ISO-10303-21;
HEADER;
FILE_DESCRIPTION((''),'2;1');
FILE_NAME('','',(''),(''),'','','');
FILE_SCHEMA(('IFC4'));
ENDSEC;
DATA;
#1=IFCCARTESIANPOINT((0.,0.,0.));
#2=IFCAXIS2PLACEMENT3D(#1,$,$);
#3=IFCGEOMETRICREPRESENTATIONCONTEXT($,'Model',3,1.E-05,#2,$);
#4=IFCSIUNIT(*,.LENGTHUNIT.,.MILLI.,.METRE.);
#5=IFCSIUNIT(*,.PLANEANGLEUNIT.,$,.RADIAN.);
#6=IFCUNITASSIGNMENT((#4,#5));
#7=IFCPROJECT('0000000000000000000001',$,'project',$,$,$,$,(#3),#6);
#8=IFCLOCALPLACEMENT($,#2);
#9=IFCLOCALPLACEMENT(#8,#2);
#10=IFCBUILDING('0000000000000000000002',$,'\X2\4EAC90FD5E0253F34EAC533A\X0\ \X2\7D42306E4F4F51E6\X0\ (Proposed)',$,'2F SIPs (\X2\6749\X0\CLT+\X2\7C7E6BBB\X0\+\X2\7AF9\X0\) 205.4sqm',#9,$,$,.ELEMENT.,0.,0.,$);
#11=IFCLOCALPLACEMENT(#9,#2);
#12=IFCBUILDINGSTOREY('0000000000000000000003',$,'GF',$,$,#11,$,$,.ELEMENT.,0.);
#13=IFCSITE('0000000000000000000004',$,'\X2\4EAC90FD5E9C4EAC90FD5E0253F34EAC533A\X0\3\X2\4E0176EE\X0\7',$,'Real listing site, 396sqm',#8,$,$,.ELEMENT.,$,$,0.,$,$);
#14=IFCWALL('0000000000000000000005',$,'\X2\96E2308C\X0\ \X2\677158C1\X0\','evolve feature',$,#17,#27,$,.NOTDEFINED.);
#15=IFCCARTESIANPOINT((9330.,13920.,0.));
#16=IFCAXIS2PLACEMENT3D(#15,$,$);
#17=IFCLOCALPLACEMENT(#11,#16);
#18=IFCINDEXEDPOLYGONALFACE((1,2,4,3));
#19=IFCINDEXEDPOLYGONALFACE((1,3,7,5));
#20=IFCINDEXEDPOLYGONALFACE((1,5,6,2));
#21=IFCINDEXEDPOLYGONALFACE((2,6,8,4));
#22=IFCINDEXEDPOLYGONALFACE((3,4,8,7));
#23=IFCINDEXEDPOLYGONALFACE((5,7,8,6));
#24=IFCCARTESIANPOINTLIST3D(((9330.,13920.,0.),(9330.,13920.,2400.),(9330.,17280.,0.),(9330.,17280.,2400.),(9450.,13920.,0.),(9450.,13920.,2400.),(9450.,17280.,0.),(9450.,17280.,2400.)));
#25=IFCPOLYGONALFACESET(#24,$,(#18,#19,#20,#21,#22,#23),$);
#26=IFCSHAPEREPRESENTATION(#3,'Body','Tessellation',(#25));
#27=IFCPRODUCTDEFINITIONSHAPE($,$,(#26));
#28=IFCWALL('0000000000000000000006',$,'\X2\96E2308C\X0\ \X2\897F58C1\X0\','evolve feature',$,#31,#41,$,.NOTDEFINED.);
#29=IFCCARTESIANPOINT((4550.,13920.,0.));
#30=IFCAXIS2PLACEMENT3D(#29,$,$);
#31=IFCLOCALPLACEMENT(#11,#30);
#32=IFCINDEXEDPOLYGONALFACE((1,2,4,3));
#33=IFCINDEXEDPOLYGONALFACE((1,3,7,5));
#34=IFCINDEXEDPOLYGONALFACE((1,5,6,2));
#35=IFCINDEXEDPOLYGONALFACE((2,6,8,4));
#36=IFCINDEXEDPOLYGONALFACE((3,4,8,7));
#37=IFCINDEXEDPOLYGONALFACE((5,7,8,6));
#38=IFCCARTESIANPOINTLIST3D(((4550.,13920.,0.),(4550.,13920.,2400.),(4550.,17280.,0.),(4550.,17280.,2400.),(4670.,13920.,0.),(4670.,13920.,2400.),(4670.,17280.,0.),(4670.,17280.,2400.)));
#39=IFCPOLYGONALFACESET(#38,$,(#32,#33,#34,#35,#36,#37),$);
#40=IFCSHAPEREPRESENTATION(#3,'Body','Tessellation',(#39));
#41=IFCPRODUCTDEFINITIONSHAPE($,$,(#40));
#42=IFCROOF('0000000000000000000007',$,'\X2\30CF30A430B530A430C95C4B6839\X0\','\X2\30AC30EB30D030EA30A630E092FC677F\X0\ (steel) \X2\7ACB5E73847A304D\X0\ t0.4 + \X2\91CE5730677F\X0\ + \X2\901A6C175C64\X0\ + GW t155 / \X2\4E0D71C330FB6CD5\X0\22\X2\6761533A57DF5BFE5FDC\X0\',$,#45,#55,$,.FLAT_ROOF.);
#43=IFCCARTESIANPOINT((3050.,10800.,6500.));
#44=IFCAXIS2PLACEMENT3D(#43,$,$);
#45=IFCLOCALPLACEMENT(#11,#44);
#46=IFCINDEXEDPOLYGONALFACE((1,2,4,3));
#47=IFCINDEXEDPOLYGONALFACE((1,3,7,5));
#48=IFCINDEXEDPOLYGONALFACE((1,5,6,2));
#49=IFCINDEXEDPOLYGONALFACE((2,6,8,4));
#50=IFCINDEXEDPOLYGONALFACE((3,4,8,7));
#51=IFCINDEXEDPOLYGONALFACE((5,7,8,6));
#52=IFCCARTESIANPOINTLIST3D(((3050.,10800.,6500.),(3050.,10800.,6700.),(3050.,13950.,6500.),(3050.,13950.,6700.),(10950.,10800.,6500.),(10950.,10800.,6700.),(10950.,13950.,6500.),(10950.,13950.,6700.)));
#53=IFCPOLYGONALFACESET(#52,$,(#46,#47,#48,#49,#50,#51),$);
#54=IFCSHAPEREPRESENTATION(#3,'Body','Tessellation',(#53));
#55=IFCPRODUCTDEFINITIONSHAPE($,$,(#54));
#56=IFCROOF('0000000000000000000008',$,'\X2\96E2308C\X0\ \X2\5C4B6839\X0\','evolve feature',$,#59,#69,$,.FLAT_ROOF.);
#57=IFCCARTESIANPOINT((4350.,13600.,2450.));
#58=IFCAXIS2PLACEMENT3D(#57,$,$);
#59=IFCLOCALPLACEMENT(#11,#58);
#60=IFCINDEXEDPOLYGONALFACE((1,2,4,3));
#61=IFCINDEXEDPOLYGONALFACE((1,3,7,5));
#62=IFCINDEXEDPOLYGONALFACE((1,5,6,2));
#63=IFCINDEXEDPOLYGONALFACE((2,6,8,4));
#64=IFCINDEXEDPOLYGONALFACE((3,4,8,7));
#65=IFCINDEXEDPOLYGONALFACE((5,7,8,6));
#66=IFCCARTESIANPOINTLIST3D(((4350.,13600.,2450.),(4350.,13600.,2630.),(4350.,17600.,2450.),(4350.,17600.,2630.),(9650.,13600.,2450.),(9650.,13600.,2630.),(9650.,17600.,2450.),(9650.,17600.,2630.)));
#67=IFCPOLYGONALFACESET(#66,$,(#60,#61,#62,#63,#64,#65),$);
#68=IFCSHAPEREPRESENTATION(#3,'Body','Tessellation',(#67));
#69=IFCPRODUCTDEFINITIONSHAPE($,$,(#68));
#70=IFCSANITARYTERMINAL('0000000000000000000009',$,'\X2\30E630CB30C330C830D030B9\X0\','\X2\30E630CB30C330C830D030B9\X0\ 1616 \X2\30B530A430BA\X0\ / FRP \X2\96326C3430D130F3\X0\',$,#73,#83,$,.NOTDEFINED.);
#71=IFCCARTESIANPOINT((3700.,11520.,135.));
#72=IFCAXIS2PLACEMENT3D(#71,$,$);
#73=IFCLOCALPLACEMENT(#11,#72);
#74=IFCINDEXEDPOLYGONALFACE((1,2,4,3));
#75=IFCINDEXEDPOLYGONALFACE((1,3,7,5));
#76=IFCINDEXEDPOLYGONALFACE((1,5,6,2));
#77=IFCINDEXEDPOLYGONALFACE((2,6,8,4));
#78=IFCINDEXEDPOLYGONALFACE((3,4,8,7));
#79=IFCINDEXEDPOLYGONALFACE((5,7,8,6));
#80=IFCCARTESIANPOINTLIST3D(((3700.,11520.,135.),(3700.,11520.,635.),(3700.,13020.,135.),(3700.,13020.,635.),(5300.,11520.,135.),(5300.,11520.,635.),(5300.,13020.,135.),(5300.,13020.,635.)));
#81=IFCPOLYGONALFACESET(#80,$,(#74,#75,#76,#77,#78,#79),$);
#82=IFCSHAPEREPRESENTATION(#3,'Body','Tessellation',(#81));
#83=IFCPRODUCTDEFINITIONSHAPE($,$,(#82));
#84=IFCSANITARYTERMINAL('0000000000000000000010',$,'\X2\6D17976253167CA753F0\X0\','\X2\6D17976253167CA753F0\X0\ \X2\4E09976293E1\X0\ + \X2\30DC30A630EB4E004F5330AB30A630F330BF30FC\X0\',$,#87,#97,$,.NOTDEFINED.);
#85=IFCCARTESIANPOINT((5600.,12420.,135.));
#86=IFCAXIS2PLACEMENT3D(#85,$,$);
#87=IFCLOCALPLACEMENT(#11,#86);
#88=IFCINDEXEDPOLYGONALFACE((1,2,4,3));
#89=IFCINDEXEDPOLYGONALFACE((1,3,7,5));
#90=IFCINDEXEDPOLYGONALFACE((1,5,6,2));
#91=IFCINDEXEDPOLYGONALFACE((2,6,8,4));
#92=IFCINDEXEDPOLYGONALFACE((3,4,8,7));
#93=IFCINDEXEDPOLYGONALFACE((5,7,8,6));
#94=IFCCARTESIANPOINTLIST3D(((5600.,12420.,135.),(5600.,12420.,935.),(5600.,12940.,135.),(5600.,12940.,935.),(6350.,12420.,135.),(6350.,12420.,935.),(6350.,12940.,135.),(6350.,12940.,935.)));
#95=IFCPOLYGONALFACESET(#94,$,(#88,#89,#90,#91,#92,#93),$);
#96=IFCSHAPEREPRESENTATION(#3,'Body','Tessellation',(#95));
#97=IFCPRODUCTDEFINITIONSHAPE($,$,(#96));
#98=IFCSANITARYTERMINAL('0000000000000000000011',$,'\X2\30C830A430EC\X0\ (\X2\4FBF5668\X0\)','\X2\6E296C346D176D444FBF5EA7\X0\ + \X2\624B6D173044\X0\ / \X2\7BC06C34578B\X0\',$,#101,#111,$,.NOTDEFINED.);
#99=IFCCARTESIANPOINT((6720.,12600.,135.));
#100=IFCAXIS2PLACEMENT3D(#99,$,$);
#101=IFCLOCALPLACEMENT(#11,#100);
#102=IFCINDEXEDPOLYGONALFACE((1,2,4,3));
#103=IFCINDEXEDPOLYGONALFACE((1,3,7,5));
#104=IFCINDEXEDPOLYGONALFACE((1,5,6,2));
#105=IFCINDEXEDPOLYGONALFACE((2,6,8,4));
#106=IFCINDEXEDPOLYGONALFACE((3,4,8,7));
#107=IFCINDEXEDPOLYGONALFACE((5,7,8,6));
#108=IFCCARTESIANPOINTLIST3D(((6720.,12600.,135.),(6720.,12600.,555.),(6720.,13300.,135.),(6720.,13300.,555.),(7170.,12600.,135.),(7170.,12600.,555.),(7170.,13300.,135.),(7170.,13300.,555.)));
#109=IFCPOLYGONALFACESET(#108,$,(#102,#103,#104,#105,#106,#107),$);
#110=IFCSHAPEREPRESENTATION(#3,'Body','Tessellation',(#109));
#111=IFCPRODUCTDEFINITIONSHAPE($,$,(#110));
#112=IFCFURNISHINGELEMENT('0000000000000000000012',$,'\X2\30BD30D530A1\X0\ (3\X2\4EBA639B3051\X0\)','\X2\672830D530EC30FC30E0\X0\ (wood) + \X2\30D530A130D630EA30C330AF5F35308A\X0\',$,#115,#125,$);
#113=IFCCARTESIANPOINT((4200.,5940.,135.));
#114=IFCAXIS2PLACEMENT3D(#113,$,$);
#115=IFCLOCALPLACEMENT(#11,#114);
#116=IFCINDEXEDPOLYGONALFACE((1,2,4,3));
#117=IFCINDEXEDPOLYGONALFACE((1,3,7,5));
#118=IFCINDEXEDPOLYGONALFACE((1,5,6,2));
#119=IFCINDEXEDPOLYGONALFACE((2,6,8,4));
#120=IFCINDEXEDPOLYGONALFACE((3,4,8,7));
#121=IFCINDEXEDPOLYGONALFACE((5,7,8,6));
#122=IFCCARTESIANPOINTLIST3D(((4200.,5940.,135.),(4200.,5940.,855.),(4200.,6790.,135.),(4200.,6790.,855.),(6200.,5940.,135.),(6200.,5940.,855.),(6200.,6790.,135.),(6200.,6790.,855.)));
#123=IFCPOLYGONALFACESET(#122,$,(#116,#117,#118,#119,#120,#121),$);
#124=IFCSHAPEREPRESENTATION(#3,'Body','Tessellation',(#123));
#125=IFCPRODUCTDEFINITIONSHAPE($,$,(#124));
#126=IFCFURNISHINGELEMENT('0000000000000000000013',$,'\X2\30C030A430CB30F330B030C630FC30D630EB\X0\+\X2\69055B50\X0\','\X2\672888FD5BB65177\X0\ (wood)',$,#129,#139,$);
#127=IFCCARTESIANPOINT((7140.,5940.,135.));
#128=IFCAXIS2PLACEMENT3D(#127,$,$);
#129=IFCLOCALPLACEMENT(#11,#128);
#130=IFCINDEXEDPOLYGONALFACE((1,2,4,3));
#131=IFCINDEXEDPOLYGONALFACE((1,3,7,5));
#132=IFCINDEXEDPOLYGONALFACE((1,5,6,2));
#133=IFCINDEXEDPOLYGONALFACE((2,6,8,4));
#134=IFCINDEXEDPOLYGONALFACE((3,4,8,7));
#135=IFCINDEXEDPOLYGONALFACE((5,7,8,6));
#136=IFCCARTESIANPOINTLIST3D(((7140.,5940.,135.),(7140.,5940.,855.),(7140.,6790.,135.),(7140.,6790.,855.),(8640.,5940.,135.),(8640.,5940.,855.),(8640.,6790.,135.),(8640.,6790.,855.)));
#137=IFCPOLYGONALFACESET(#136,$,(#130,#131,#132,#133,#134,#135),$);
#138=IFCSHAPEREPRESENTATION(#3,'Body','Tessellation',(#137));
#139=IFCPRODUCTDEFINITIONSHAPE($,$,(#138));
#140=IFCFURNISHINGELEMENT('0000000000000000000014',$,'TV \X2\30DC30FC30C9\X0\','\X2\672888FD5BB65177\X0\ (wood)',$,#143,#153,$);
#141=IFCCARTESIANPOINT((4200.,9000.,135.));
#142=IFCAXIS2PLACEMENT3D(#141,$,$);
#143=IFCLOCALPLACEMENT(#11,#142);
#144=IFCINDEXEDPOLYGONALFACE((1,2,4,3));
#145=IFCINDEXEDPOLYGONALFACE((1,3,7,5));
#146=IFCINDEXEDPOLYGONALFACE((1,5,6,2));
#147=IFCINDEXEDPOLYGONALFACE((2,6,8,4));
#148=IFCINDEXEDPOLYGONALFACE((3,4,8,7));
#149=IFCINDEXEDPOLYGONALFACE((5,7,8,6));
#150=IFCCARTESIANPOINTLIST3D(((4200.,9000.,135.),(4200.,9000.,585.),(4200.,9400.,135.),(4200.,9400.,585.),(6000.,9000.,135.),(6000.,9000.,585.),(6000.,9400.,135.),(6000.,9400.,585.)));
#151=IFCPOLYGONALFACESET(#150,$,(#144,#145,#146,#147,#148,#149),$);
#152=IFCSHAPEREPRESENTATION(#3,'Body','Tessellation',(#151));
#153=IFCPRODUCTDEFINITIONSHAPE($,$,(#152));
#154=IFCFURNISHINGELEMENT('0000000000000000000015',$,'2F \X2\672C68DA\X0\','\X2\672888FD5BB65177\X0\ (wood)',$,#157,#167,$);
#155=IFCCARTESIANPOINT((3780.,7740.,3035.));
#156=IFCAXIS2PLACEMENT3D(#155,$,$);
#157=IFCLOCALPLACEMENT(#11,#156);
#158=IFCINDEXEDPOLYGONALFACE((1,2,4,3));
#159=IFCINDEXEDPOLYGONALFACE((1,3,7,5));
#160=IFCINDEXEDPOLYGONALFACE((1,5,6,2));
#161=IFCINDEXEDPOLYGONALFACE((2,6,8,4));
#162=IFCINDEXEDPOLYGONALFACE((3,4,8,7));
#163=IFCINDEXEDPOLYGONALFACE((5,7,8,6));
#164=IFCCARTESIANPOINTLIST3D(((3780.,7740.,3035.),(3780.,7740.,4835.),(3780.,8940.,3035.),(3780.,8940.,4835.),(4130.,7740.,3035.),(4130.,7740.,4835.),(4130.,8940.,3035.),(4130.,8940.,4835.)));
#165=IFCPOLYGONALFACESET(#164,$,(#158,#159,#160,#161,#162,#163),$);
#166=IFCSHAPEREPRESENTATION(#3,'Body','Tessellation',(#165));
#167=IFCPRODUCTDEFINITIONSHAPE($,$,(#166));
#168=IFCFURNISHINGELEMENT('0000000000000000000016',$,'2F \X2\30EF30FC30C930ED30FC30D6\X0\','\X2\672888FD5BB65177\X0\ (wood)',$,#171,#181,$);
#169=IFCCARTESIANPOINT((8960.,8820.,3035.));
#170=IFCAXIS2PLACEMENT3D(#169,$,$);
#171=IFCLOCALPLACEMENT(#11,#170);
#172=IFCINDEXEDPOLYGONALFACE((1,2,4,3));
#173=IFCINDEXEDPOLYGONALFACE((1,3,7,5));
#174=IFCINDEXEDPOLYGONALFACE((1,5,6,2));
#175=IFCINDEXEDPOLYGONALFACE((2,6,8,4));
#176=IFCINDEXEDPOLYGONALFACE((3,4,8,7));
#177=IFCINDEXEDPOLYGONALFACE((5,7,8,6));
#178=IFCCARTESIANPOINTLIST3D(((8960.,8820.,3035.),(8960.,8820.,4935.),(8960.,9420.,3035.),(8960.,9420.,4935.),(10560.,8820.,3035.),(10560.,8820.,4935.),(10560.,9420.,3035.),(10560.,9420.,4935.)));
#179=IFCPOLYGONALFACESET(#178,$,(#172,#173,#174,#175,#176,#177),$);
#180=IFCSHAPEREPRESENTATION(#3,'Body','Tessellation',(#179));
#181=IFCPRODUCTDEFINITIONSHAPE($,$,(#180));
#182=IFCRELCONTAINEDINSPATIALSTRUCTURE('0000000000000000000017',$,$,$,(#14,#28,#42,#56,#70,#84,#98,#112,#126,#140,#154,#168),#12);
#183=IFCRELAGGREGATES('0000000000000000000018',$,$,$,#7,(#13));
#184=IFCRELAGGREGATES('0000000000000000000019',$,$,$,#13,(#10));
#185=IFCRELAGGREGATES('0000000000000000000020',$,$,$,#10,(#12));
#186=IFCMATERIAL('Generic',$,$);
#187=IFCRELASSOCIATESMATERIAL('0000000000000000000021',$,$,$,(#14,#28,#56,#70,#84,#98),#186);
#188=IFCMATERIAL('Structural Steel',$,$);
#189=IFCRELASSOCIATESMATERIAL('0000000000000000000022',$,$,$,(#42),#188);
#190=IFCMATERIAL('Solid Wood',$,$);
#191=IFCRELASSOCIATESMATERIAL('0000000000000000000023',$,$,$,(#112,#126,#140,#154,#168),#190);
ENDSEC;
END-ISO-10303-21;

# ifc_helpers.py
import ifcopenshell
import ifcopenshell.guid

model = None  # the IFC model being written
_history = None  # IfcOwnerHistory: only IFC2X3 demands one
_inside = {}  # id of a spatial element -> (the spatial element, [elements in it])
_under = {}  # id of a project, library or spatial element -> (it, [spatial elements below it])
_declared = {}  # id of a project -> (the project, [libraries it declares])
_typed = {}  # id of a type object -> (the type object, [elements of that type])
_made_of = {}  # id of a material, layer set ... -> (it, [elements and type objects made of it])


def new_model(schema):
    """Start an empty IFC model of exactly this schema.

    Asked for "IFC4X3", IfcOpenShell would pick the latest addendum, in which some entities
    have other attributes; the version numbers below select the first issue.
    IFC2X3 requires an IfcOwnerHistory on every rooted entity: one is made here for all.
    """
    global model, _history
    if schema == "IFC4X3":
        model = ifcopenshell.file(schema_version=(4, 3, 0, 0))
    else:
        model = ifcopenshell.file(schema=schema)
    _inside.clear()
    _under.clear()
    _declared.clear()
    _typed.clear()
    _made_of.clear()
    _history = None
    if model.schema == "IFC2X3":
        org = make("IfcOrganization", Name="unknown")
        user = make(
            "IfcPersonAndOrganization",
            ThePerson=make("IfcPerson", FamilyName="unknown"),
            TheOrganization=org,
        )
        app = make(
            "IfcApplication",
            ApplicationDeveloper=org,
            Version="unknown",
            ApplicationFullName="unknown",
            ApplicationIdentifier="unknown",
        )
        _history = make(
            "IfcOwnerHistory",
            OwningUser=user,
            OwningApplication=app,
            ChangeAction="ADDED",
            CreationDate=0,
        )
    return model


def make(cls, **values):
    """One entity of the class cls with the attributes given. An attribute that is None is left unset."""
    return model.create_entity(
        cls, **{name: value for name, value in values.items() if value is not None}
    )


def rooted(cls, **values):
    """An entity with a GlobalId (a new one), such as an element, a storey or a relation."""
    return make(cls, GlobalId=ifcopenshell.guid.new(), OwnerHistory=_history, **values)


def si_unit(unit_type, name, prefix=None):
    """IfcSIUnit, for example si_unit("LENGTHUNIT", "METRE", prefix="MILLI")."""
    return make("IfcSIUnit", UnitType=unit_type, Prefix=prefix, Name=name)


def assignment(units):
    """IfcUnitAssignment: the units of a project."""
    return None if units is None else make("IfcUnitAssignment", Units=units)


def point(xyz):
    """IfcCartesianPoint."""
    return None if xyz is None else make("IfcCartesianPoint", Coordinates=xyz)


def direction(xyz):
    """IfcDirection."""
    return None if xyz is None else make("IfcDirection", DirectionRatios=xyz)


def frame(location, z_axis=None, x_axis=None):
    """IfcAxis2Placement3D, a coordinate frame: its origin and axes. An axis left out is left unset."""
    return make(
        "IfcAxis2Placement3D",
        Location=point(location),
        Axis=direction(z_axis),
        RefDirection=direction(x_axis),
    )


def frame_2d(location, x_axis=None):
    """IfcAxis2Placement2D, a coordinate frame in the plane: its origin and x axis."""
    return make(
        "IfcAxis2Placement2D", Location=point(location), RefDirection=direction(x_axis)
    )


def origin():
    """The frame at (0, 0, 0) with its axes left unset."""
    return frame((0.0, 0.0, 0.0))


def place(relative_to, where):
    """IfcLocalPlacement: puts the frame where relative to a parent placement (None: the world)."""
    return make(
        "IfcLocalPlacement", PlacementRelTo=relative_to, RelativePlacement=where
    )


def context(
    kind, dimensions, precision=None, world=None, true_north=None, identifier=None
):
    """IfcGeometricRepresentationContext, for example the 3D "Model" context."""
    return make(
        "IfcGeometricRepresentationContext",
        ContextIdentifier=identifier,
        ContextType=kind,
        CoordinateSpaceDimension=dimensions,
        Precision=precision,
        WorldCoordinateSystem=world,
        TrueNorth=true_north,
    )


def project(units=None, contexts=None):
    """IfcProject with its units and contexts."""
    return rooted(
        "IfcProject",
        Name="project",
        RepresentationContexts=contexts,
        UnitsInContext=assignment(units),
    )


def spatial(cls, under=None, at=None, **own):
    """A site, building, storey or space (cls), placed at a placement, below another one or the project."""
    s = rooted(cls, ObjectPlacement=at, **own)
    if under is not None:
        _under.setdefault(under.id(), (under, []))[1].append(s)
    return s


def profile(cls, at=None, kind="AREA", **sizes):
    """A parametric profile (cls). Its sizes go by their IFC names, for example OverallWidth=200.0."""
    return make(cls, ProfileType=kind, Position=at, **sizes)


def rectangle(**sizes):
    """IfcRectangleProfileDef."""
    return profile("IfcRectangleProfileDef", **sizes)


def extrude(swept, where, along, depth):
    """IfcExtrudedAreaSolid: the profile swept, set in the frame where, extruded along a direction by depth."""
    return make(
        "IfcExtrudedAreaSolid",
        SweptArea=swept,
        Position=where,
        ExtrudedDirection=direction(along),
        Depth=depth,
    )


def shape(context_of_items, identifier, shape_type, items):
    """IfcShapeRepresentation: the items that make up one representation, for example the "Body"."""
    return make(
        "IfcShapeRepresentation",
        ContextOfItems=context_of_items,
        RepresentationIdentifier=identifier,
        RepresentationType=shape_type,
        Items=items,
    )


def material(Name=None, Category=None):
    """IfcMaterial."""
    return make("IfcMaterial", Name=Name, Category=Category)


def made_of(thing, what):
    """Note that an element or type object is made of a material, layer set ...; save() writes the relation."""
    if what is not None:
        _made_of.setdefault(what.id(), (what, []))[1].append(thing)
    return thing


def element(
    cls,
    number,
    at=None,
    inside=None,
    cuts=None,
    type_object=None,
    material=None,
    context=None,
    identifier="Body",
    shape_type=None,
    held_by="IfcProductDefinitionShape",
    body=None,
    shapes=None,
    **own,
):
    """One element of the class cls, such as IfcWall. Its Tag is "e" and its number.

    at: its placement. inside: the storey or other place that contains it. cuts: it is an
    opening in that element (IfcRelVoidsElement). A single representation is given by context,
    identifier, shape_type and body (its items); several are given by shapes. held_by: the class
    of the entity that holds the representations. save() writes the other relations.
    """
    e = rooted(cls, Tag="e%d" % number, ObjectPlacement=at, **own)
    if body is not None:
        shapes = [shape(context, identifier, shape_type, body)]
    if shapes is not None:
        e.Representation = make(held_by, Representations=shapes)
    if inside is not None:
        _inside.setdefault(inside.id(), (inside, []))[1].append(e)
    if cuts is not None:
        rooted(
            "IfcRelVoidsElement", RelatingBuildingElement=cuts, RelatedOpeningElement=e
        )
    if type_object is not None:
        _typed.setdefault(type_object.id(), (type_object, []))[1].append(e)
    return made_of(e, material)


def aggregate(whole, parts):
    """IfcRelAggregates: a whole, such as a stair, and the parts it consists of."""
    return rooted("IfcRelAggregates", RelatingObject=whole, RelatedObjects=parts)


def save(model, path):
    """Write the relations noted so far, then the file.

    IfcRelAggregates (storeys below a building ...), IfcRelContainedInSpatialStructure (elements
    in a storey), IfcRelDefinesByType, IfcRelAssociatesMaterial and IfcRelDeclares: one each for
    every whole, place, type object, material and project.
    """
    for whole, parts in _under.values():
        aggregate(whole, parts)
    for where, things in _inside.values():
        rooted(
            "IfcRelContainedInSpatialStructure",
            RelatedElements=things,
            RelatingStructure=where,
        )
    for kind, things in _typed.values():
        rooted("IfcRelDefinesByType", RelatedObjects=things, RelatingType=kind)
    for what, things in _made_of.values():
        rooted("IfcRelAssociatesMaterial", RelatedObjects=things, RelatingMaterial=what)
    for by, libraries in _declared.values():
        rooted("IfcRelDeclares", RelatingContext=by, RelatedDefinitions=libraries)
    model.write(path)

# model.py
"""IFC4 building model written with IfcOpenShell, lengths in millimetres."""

from ifc_helpers import new_model, si_unit, frame, frame_2d, origin, place, context, project, spatial, rectangle, extrude, material, element, save


model = new_model("IFC4")

# Units and contexts
model_context = context("Model", 3, precision=1e-05, world=origin())
ifc_project = project(units=[si_unit("LENGTHUNIT", "METRE", prefix="MILLI"), si_unit("PLANEANGLEUNIT", "RADIAN")], contexts=[model_context])

# Site, building, storey
site_placement = place(None, origin())
site = spatial("IfcSite", under=ifc_project, at=site_placement, Name="京都府京都市右京区3丁目7", ObjectType="Real listing site, 396sqm", CompositionType="ELEMENT", RefElevation=0.0)
building_placement = place(site_placement, origin())
building = spatial("IfcBuilding", under=site, at=building_placement, Name="京都市右京区 終の住処 (Proposed)", ObjectType="2F SIPs (杉CLT+籾殻+竹) 205.4sqm", CompositionType="ELEMENT", ElevationOfRefHeight=0.0, ElevationOfTerrain=0.0)
storey_placement = place(building_placement, origin())
storey = spatial("IfcBuildingStorey", under=building, at=storey_placement, Name="GF", CompositionType="ELEMENT", Elevation=0.0)

# Shared definitions
ifc_material_1 = material(Name="Generic")

# Shared definitions
ifc_material_2 = material(Name="Solid Wood")

# Walls
wall_1_placement = place(storey_placement, frame((9330.0, 13920.0, 0.0)))
element("IfcWall", 1, at=wall_1_placement, inside=storey, material=ifc_material_1, Name="離れ 東壁", Description="evolve feature", PredefinedType="NOTDEFINED", context=model_context, shape_type="SweptSolid", body=[
    extrude(rectangle(XDim=120.0, YDim=3360.0, at=frame_2d((60.0, 1680.0))), frame((9330.0, 13920.0, 0.0)), (0.0, 0.0, 1.0), 2400.0),
])
wall_2_placement = place(storey_placement, frame((4550.0, 13920.0, 0.0)))
element("IfcWall", 2, at=wall_2_placement, inside=storey, material=ifc_material_1, Name="離れ 西壁", Description="evolve feature", PredefinedType="NOTDEFINED", context=model_context, shape_type="SweptSolid", body=[
    extrude(rectangle(XDim=120.0, YDim=3360.0, at=frame_2d((60.0, 1680.0))), frame((4550.0, 13920.0, 0.0)), (0.0, 0.0, 1.0), 2400.0),
])

# Roofs
ifc_material_3 = material(Name="Structural Steel")
roof_1_placement = place(storey_placement, frame((3050.0, 10800.0, 6500.0)))
element("IfcRoof", 3, at=roof_1_placement, inside=storey, material=ifc_material_3, Name="ハイサイド屋根", Description="ガルバリウム鋼板 (steel) 立平葺き t0.4 + 野地板 + 通気層 + GW t155 / 不燃・法22条区域対応", PredefinedType="FLAT_ROOF", context=model_context, shape_type="SweptSolid", body=[
    extrude(rectangle(XDim=7900.0, YDim=3150.0, at=frame_2d((3950.0, 1575.0))), frame((3050.0, 10800.0, 6500.0)), (0.0, 0.0, 1.0), 200.0),
])
roof_2_placement = place(storey_placement, frame((4350.0, 13600.0, 2450.0)))
element("IfcRoof", 4, at=roof_2_placement, inside=storey, material=ifc_material_1, Name="離れ 屋根", Description="evolve feature", PredefinedType="FLAT_ROOF", context=model_context, shape_type="SweptSolid", body=[
    extrude(rectangle(XDim=5300.0, YDim=4000.0, at=frame_2d((2650.0, 2000.0))), frame((4350.0, 13600.0, 2450.0)), (0.0, 0.0, 1.0), 180.0),
])

# Sanitary terminals
sanitary_terminal_1_placement = place(storey_placement, frame((3700.0, 11520.0, 135.0)))
element("IfcSanitaryTerminal", 5, at=sanitary_terminal_1_placement, inside=storey, material=ifc_material_1, Name="ユニットバス", Description="ユニットバス 1616 サイズ / FRP 防水パン", PredefinedType="NOTDEFINED", context=model_context, shape_type="SweptSolid", body=[
    extrude(rectangle(XDim=1600.0, YDim=1500.0, at=frame_2d((800.0, 750.0))), frame((3700.0, 11520.0, 135.0)), (0.0, 0.0, 1.0), 500.0),
])
sanitary_terminal_2_placement = place(storey_placement, frame((5600.0, 12420.0, 135.0)))
element("IfcSanitaryTerminal", 6, at=sanitary_terminal_2_placement, inside=storey, material=ifc_material_1, Name="洗面化粧台", Description="洗面化粧台 三面鏡 + ボウル一体カウンター", PredefinedType="NOTDEFINED", context=model_context, shape_type="SweptSolid", body=[
    extrude(rectangle(XDim=750.0, YDim=520.0, at=frame_2d((375.0, 260.0))), frame((5600.0, 12420.0, 135.0)), (0.0, 0.0, 1.0), 800.0),
])
sanitary_terminal_3_placement = place(storey_placement, frame((6720.0, 12600.0, 135.0)))
element("IfcSanitaryTerminal", 7, at=sanitary_terminal_3_placement, inside=storey, material=ifc_material_1, Name="トイレ (便器)", Description="温水洗浄便座 + 手洗い / 節水型", PredefinedType="NOTDEFINED", context=model_context, shape_type="SweptSolid", body=[
    extrude(rectangle(XDim=450.0, YDim=700.0, at=frame_2d((225.0, 350.0))), frame((6720.0, 12600.0, 135.0)), (0.0, 0.0, 1.0), 420.0),
])

# Furnishing elements
furnishing_1_placement = place(storey_placement, frame((4200.0, 5940.0, 135.0)))
element("IfcFurnishingElement", 8, at=furnishing_1_placement, inside=storey, material=ifc_material_2, Name="ソファ (3人掛け)", Description="木フレーム (wood) + ファブリック張り", context=model_context, shape_type="SweptSolid", body=[
    extrude(rectangle(XDim=2000.0, YDim=850.0, at=frame_2d((1000.0, 425.0))), frame((4200.0, 5940.0, 135.0)), (0.0, 0.0, 1.0), 720.0),
])
furnishing_2_placement = place(storey_placement, frame((7140.0, 5940.0, 135.0)))
element("IfcFurnishingElement", 9, at=furnishing_2_placement, inside=storey, material=ifc_material_2, Name="ダイニングテーブル+椅子", Description="木製家具 (wood)", context=model_context, shape_type="SweptSolid", body=[
    extrude(rectangle(XDim=1500.0, YDim=850.0, at=frame_2d((750.0, 425.0))), frame((7140.0, 5940.0, 135.0)), (0.0, 0.0, 1.0), 720.0),
])
furnishing_3_placement = place(storey_placement, frame((4200.0, 9000.0, 135.0)))
element("IfcFurnishingElement", 10, at=furnishing_3_placement, inside=storey, material=ifc_material_2, Name="TV ボード", Description="木製家具 (wood)", context=model_context, shape_type="SweptSolid", body=[
    extrude(rectangle(XDim=1800.0, YDim=400.0, at=frame_2d((900.0, 200.0))), frame((4200.0, 9000.0, 135.0)), (0.0, 0.0, 1.0), 450.0),
])
furnishing_4_placement = place(storey_placement, frame((3780.0, 7740.0, 3035.0)))
element("IfcFurnishingElement", 11, at=furnishing_4_placement, inside=storey, material=ifc_material_2, Name="2F 本棚", Description="木製家具 (wood)", context=model_context, shape_type="SweptSolid", body=[
    extrude(rectangle(XDim=350.0, YDim=1200.0, at=frame_2d((175.0, 600.0))), frame((3780.0, 7740.0, 3035.0)), (0.0, 0.0, 1.0), 1800.0),
])
furnishing_5_placement = place(storey_placement, frame((8960.0, 8820.0, 3035.0)))
element("IfcFurnishingElement", 12, at=furnishing_5_placement, inside=storey, material=ifc_material_2, Name="2F ワードローブ", Description="木製家具 (wood)", context=model_context, shape_type="SweptSolid", body=[
    extrude(rectangle(XDim=1600.0, YDim=600.0, at=frame_2d((800.0, 300.0))), frame((8960.0, 8820.0, 3035.0)), (0.0, 0.0, 1.0), 1900.0),
])

save(model, "model.ifc")
